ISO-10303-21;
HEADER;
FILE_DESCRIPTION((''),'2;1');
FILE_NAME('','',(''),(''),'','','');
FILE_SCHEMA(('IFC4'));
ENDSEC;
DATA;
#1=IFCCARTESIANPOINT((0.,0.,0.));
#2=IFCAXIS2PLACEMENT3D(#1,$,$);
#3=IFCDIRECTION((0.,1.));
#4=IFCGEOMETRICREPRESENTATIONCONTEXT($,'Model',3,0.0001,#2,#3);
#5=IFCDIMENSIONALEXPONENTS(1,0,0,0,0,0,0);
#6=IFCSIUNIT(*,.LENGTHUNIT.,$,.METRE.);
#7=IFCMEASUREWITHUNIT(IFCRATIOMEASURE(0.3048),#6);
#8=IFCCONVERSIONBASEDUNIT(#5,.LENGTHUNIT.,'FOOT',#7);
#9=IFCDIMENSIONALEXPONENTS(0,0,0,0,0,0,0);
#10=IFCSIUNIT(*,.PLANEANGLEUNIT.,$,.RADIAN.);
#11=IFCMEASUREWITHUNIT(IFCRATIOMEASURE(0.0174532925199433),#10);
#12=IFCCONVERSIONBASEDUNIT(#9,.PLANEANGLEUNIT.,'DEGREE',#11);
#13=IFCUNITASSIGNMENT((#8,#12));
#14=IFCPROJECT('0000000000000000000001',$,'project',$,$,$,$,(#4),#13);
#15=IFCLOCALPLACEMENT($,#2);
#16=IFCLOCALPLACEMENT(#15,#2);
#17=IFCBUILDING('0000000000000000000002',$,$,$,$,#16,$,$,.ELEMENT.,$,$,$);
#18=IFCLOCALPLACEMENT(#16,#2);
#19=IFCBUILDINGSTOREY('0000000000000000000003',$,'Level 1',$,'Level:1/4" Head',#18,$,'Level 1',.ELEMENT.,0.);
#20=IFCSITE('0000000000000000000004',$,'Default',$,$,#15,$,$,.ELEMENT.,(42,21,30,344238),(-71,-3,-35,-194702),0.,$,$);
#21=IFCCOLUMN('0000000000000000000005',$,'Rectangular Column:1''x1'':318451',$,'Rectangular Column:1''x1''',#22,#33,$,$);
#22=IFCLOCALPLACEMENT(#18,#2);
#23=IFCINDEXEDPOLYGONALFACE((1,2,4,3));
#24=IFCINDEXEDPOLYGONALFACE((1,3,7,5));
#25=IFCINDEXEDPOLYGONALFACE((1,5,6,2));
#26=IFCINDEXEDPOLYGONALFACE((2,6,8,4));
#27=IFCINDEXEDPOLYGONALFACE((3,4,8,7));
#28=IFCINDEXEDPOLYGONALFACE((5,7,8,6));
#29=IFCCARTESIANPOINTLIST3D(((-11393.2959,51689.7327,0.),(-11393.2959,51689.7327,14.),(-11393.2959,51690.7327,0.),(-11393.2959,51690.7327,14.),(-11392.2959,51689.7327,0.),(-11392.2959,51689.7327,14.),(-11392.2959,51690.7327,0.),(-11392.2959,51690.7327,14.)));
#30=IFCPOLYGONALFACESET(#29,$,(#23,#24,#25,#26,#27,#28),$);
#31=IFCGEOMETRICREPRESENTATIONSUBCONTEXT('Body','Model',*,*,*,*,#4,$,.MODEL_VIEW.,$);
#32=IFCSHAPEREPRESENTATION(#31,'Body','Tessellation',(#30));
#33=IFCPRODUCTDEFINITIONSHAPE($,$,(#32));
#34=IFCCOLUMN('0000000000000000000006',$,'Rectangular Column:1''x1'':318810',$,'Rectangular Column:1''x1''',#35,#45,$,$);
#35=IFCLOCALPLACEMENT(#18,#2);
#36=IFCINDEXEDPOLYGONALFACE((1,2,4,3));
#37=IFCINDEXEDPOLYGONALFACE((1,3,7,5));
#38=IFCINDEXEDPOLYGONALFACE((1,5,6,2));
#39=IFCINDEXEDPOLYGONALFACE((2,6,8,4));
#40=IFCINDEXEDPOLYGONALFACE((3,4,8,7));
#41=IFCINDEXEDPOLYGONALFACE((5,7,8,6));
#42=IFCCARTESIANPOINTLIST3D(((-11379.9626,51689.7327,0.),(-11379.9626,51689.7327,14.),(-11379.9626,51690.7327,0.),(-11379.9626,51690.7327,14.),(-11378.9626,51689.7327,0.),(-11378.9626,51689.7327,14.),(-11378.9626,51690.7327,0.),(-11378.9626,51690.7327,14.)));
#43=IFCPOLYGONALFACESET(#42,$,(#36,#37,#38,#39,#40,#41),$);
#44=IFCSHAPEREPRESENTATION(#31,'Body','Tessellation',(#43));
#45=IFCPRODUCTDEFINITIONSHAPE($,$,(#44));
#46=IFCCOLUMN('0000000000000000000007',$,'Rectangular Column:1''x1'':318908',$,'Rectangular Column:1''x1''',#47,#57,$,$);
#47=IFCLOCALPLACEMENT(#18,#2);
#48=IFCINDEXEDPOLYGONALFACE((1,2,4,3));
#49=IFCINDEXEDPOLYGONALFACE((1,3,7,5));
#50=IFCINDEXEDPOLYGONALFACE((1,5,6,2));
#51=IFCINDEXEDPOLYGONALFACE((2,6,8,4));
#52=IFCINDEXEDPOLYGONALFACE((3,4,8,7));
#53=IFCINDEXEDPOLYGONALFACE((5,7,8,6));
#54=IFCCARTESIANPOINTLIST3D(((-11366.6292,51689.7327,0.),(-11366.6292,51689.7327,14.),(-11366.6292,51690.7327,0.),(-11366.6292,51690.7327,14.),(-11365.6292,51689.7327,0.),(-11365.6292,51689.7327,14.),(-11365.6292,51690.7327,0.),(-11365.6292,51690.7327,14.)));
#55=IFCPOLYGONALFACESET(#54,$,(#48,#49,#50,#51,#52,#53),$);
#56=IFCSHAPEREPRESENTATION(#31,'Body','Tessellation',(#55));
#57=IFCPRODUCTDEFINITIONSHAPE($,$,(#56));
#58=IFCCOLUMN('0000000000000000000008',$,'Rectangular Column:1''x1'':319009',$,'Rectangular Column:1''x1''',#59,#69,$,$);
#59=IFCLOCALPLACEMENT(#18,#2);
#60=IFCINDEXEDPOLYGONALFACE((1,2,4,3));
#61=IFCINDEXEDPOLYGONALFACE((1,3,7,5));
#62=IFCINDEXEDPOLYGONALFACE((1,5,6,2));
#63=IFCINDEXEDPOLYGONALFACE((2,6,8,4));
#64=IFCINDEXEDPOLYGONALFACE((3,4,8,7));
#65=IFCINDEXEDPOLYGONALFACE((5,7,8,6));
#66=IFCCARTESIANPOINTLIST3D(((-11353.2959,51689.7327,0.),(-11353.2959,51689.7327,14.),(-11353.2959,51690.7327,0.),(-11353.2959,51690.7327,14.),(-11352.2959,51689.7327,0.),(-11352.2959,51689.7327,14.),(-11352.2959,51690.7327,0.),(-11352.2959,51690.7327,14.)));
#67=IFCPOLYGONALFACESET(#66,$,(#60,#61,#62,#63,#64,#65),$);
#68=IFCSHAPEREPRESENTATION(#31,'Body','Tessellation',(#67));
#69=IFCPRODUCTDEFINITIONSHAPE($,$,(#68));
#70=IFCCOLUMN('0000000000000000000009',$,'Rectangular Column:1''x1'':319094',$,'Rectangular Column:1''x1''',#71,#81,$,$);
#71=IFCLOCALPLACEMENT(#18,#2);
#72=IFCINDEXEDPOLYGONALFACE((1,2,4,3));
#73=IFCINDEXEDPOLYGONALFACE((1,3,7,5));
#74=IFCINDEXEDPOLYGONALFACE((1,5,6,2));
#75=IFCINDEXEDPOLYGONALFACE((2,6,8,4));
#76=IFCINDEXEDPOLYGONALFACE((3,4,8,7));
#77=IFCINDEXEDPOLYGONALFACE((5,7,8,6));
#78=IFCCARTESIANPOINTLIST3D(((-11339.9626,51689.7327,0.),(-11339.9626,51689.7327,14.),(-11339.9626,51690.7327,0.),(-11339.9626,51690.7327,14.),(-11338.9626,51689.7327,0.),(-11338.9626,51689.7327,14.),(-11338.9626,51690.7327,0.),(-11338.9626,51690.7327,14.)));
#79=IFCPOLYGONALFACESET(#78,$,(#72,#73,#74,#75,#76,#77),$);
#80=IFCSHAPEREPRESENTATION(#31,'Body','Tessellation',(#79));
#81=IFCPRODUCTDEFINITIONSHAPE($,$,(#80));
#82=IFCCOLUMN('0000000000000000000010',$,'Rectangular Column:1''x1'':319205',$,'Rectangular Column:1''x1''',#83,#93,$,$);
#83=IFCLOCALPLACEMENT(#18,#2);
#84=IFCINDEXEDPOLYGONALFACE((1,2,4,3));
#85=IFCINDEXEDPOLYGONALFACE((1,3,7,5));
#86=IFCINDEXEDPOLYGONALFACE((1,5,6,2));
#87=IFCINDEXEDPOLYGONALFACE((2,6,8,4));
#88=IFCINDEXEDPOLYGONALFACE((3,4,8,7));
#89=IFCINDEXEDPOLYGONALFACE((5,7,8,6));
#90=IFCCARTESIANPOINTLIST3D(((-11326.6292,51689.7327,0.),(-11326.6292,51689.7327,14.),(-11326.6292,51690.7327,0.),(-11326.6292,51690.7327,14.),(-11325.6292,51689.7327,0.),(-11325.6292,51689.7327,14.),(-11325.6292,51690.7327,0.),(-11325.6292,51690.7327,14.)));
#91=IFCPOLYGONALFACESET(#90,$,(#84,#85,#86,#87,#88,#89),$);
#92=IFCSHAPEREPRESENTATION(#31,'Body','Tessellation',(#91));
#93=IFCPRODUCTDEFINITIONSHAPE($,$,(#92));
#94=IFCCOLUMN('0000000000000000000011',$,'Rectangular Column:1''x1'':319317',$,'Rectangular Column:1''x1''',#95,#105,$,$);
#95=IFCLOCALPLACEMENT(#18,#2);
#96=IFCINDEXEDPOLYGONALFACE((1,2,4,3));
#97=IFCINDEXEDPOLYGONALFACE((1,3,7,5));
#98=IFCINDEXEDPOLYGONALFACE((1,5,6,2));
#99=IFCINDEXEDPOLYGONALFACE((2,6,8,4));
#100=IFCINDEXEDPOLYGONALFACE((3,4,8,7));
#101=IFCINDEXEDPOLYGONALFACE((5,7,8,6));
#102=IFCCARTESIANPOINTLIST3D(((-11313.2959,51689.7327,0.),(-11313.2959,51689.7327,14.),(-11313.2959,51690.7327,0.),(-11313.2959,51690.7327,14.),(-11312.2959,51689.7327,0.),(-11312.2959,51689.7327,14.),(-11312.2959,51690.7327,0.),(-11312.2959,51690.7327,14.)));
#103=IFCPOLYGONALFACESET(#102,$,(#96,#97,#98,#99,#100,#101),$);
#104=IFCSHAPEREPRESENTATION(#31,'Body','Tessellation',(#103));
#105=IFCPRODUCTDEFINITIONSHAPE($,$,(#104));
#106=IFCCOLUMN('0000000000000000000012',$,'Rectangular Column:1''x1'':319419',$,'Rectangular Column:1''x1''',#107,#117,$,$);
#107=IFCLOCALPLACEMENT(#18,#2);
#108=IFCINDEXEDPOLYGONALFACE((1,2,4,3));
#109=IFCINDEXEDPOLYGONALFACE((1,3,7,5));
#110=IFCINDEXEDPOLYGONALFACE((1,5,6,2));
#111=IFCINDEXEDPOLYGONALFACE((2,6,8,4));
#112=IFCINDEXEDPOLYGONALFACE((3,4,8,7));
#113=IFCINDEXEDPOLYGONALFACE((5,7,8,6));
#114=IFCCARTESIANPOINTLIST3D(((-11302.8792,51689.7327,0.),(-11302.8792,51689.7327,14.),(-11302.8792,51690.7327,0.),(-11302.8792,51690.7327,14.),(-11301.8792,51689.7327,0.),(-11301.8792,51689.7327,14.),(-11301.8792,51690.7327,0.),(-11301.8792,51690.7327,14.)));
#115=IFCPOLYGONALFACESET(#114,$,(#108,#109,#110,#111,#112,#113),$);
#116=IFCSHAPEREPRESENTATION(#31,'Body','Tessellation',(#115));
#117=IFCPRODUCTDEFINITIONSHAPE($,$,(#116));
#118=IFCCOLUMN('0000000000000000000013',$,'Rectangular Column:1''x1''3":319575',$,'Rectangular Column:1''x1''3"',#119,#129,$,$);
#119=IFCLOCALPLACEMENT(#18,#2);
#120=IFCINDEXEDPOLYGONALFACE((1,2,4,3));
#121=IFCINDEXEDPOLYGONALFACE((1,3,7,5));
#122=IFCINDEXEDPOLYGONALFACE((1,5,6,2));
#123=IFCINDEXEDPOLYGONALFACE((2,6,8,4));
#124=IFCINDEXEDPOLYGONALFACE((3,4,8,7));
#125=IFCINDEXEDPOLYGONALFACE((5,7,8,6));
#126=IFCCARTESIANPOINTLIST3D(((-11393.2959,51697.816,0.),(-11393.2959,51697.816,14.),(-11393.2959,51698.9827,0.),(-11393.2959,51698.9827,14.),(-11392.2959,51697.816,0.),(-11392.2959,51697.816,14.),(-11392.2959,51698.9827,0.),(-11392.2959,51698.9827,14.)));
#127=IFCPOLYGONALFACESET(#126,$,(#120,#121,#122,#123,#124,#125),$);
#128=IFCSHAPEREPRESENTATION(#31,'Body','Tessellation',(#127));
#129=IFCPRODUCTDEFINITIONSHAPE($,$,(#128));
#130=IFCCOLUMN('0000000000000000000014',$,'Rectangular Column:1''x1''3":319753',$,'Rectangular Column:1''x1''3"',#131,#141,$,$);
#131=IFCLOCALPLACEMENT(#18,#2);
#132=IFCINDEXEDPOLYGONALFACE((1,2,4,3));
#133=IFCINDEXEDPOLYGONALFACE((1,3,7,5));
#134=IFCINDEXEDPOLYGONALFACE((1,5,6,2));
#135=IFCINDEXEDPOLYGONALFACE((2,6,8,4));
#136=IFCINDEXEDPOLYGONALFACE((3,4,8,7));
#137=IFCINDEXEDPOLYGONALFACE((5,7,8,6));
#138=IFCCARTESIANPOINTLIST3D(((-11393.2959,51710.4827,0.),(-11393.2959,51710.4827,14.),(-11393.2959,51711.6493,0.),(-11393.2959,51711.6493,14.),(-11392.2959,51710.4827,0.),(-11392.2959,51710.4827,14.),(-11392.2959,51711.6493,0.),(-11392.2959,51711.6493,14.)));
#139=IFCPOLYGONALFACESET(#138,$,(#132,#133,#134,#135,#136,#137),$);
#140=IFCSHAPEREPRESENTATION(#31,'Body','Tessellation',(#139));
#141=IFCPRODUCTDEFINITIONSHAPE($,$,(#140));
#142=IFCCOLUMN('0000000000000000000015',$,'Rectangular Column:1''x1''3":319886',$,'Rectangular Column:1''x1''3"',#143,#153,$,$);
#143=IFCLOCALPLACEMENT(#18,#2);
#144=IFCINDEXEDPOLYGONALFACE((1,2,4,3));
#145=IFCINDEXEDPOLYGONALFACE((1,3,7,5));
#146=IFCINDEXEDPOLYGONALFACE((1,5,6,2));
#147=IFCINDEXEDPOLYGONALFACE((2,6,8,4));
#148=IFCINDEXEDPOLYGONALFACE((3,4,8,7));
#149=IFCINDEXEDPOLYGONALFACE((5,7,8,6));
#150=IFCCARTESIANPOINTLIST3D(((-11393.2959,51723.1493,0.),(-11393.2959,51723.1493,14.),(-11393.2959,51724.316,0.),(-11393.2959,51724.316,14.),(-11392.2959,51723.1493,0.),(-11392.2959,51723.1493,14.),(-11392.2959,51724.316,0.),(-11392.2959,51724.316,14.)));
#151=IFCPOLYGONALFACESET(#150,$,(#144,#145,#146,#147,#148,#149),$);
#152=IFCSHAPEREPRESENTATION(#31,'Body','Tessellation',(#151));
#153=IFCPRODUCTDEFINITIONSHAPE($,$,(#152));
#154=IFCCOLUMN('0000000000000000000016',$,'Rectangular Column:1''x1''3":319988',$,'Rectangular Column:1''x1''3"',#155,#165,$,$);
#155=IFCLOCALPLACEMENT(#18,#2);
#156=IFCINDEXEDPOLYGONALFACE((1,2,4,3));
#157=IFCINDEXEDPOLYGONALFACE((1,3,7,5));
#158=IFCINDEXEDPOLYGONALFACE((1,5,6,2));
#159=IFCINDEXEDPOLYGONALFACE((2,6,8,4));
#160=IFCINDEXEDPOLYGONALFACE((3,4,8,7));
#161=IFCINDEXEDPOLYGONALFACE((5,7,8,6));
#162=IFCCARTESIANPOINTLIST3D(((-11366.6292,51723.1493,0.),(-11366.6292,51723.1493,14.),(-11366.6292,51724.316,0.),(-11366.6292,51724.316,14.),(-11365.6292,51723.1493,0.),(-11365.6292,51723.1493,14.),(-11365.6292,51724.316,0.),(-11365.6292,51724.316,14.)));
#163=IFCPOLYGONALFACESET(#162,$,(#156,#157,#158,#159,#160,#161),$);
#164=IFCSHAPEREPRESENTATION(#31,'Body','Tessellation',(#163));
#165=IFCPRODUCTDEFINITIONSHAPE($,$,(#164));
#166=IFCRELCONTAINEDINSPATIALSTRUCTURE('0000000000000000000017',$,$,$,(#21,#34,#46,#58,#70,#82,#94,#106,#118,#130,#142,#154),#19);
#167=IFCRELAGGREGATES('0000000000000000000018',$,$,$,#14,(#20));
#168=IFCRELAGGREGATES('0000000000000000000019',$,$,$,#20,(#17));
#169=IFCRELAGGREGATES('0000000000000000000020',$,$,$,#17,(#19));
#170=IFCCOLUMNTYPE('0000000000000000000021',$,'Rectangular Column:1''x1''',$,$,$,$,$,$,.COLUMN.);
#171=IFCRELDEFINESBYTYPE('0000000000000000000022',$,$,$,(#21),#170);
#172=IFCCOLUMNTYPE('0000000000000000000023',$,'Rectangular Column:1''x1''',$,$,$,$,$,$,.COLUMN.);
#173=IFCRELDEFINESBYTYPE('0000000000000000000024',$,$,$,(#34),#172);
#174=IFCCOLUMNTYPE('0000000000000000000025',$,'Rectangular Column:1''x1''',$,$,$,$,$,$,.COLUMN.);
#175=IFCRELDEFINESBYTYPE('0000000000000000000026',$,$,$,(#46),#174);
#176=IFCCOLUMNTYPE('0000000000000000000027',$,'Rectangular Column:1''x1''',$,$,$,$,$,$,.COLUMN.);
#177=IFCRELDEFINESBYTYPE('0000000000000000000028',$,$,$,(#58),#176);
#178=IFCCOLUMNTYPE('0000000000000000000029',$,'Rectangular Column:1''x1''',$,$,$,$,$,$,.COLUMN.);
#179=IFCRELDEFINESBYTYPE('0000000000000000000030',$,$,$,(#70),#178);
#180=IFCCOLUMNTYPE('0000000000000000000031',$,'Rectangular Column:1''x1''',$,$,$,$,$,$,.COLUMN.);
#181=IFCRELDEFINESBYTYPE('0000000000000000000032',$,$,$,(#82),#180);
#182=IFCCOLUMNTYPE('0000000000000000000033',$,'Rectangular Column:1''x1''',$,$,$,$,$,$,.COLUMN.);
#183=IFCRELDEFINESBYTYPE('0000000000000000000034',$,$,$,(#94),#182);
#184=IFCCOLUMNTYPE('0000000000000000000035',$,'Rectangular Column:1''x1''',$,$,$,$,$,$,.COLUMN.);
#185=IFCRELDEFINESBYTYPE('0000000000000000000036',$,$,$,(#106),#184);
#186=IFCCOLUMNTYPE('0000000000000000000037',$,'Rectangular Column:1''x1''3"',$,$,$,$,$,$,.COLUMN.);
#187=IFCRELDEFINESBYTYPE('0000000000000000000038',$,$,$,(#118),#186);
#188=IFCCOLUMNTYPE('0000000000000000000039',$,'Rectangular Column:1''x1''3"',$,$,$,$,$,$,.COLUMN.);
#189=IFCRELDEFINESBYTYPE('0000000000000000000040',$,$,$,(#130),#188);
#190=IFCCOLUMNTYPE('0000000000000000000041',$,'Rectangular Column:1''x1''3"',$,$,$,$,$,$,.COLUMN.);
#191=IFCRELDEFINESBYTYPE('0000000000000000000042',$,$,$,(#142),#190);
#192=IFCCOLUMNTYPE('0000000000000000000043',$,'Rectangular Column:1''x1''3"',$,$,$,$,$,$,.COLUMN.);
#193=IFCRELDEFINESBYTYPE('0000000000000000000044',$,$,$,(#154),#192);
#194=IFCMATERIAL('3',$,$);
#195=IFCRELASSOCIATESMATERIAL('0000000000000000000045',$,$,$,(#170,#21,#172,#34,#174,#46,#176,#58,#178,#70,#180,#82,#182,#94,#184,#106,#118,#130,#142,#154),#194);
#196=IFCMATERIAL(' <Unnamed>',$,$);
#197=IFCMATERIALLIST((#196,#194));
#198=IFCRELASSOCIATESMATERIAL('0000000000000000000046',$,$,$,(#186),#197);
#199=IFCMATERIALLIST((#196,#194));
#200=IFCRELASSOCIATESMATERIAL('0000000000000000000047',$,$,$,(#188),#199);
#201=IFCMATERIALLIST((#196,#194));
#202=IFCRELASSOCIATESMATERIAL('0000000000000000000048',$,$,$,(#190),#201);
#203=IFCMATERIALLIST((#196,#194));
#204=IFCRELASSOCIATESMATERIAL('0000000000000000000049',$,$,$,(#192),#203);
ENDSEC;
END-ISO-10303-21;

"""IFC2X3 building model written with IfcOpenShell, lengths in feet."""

from ifc_helpers import new_model, entity, si_unit, converted_unit, direction, frame, frame_2d, origin, origin_2d_with_axis, place, context, subcontext, project, spatial, rectangle, extrude, source, transform, mapped, material, material_list, type_object, type_shapes, element, save


model = new_model("IFC2X3")

# Units and contexts
model_context = context("Model", 3, precision=0.0001, world=origin(), true_north=direction((0.0, 1.0)))
body_context = subcontext(model_context, "Body", "Model", "MODEL_VIEW")
ifc_project = project(units=[converted_unit("LENGTHUNIT", "FOOT", entity("IfcRatioMeasure", 0.3048), si_unit("LENGTHUNIT", "METRE"), dimensions=[1, 0, 0, 0, 0, 0, 0]), converted_unit("PLANEANGLEUNIT", "DEGREE", entity("IfcRatioMeasure", 0.0174532925199433), si_unit("PLANEANGLEUNIT", "RADIAN"), dimensions=[0, 0, 0, 0, 0, 0, 0])], contexts=[model_context])

# Site, building, storey
site_placement = place(None, origin())
site = spatial("IfcSite", under=ifc_project, at=site_placement, Name="Default", CompositionType="ELEMENT", RefLatitude=(42, 21, 30, 344238), RefLongitude=(-71, -3, -35, -194702), RefElevation=0.0)
building_placement = place(site_placement, origin())
building = spatial("IfcBuilding", under=site, at=building_placement, CompositionType="ELEMENT")
storey_placement = place(building_placement, origin())
storey = spatial("IfcBuildingStorey", under=building, at=storey_placement, Name="Level 1", ObjectType="Level:1/4\" Head", LongName="Level 1", CompositionType="ELEMENT", Elevation=0.0)

# Columns
ifc_material_1 = material(Name="3")
column_type_1 = type_object("IfcColumnType", Name="Rectangular Column:1'x1'", PredefinedType="COLUMN", material=ifc_material_1)
shared_shape_1 = source(origin(), body_context, "Body", "SweptSolid", [
    extrude(rectangle(XDim=1.0, YDim=1.0, at=origin_2d_with_axis()), frame((-11392.7959, 51690.2327, 0.0), z_axis=(0.0, 0.0, 1.0), x_axis=(-1.0, 0.0, 0.0)), (0.0, 0.0, 1.0), 14.0),
])
type_shapes(column_type_1, [shared_shape_1])
column_1_placement = place(storey_placement, origin())
element("IfcColumn", 1, at=column_1_placement, inside=storey, type_object=column_type_1, material=ifc_material_1, Name="Rectangular Column:1'x1':318451", ObjectType="Rectangular Column:1'x1'", context=body_context, shape_type="MappedRepresentation", body=[
    mapped(shared_shape_1, transform((0.0, 0.0, 0.0), scale=1.0)),
])
column_type_2 = type_object("IfcColumnType", Name="Rectangular Column:1'x1'", PredefinedType="COLUMN", material=ifc_material_1)
shared_shape_2 = source(origin(), body_context, "Body", "SweptSolid", [
    extrude(rectangle(XDim=1.0, YDim=1.0, at=origin_2d_with_axis()), frame((-11379.4626, 51690.2327, 0.0), z_axis=(0.0, 0.0, 1.0), x_axis=(-1.0, 0.0, 0.0)), (0.0, 0.0, 1.0), 14.0),
])
type_shapes(column_type_2, [shared_shape_2])
column_2_placement = place(storey_placement, origin())
element("IfcColumn", 2, at=column_2_placement, inside=storey, type_object=column_type_2, material=ifc_material_1, Name="Rectangular Column:1'x1':318810", ObjectType="Rectangular Column:1'x1'", context=body_context, shape_type="MappedRepresentation", body=[
    mapped(shared_shape_2, transform((0.0, 0.0, 0.0), scale=1.0)),
])
column_type_3 = type_object("IfcColumnType", Name="Rectangular Column:1'x1'", PredefinedType="COLUMN", material=ifc_material_1)
shared_shape_3 = source(origin(), body_context, "Body", "SweptSolid", [
    extrude(rectangle(XDim=1.0, YDim=1.0, at=origin_2d_with_axis()), frame((-11366.1292, 51690.2327, 0.0), z_axis=(0.0, 0.0, 1.0), x_axis=(-1.0, 0.0, 0.0)), (0.0, 0.0, 1.0), 14.0),
])
type_shapes(column_type_3, [shared_shape_3])
column_3_placement = place(storey_placement, origin())
element("IfcColumn", 3, at=column_3_placement, inside=storey, type_object=column_type_3, material=ifc_material_1, Name="Rectangular Column:1'x1':318908", ObjectType="Rectangular Column:1'x1'", context=body_context, shape_type="MappedRepresentation", body=[
    mapped(shared_shape_3, transform((0.0, 0.0, 0.0), scale=1.0)),
])
column_type_4 = type_object("IfcColumnType", Name="Rectangular Column:1'x1'", PredefinedType="COLUMN", material=ifc_material_1)
shared_shape_4 = source(origin(), body_context, "Body", "SweptSolid", [
    extrude(rectangle(XDim=1.0, YDim=1.0, at=origin_2d_with_axis()), frame((-11352.7959, 51690.2327, 0.0), z_axis=(0.0, 0.0, 1.0), x_axis=(-1.0, 0.0, 0.0)), (0.0, 0.0, 1.0), 14.0),
])
type_shapes(column_type_4, [shared_shape_4])
column_4_placement = place(storey_placement, origin())
element("IfcColumn", 4, at=column_4_placement, inside=storey, type_object=column_type_4, material=ifc_material_1, Name="Rectangular Column:1'x1':319009", ObjectType="Rectangular Column:1'x1'", context=body_context, shape_type="MappedRepresentation", body=[
    mapped(shared_shape_4, transform((0.0, 0.0, 0.0), scale=1.0)),
])
column_type_5 = type_object("IfcColumnType", Name="Rectangular Column:1'x1'", PredefinedType="COLUMN", material=ifc_material_1)
shared_shape_5 = source(origin(), body_context, "Body", "SweptSolid", [
    extrude(rectangle(XDim=1.0, YDim=1.0, at=origin_2d_with_axis()), frame((-11339.4626, 51690.2327, 0.0), z_axis=(0.0, 0.0, 1.0), x_axis=(-1.0, 0.0, 0.0)), (0.0, 0.0, 1.0), 14.0),
])
type_shapes(column_type_5, [shared_shape_5])
column_5_placement = place(storey_placement, origin())
element("IfcColumn", 5, at=column_5_placement, inside=storey, type_object=column_type_5, material=ifc_material_1, Name="Rectangular Column:1'x1':319094", ObjectType="Rectangular Column:1'x1'", context=body_context, shape_type="MappedRepresentation", body=[
    mapped(shared_shape_5, transform((0.0, 0.0, 0.0), scale=1.0)),
])
column_type_6 = type_object("IfcColumnType", Name="Rectangular Column:1'x1'", PredefinedType="COLUMN", material=ifc_material_1)
shared_shape_6 = source(origin(), body_context, "Body", "SweptSolid", [
    extrude(rectangle(XDim=1.0, YDim=1.0, at=origin_2d_with_axis()), frame((-11326.1292, 51690.2327, 0.0), z_axis=(0.0, 0.0, 1.0), x_axis=(-1.0, 0.0, 0.0)), (0.0, 0.0, 1.0), 14.0),
])
type_shapes(column_type_6, [shared_shape_6])
column_6_placement = place(storey_placement, origin())
element("IfcColumn", 6, at=column_6_placement, inside=storey, type_object=column_type_6, material=ifc_material_1, Name="Rectangular Column:1'x1':319205", ObjectType="Rectangular Column:1'x1'", context=body_context, shape_type="MappedRepresentation", body=[
    mapped(shared_shape_6, transform((0.0, 0.0, 0.0), scale=1.0)),
])
column_type_7 = type_object("IfcColumnType", Name="Rectangular Column:1'x1'", PredefinedType="COLUMN", material=ifc_material_1)
shared_shape_7 = source(origin(), body_context, "Body", "SweptSolid", [
    extrude(rectangle(XDim=1.0, YDim=1.0, at=origin_2d_with_axis()), frame((-11312.7959, 51690.2327, 0.0), z_axis=(0.0, 0.0, 1.0), x_axis=(-1.0, 0.0, 0.0)), (0.0, 0.0, 1.0), 14.0),
])
type_shapes(column_type_7, [shared_shape_7])
column_7_placement = place(storey_placement, origin())
element("IfcColumn", 7, at=column_7_placement, inside=storey, type_object=column_type_7, material=ifc_material_1, Name="Rectangular Column:1'x1':319317", ObjectType="Rectangular Column:1'x1'", context=body_context, shape_type="MappedRepresentation", body=[
    mapped(shared_shape_7, transform((0.0, 0.0, 0.0), scale=1.0)),
])
column_type_8 = type_object("IfcColumnType", Name="Rectangular Column:1'x1'", PredefinedType="COLUMN", material=ifc_material_1)
shared_shape_8 = source(origin(), body_context, "Body", "SweptSolid", [
    extrude(rectangle(XDim=1.0, YDim=1.0, at=origin_2d_with_axis()), frame((-11302.3792, 51690.2327, 0.0), z_axis=(0.0, 0.0, 1.0), x_axis=(-1.0, 0.0, 0.0)), (0.0, 0.0, 1.0), 14.0),
])
type_shapes(column_type_8, [shared_shape_8])
column_8_placement = place(storey_placement, origin())
element("IfcColumn", 8, at=column_8_placement, inside=storey, type_object=column_type_8, material=ifc_material_1, Name="Rectangular Column:1'x1':319419", ObjectType="Rectangular Column:1'x1'", context=body_context, shape_type="MappedRepresentation", body=[
    mapped(shared_shape_8, transform((0.0, 0.0, 0.0), scale=1.0)),
])
ifc_material_2 = material(Name=" <Unnamed>")
ifc_material_list_1 = material_list([ifc_material_2, ifc_material_1])
column_type_9 = type_object("IfcColumnType", Name="Rectangular Column:1'x1'3\"", PredefinedType="COLUMN", material=ifc_material_list_1)
shared_shape_9 = source(origin(), body_context, "Body", "SweptSolid", [
    extrude(rectangle(XDim=1.1667, YDim=1.0, at=frame_2d((0.0, 0.0), x_axis=(1.0, 0.0))), frame((-11392.7959, 51698.3993, 0.0), z_axis=(0.0, 0.0, 1.0), x_axis=(0.0, -1.0, 0.0)), (0.0, 0.0, 1.0), 14.0),
])
type_shapes(column_type_9, [shared_shape_9])
column_9_placement = place(storey_placement, origin())
element("IfcColumn", 9, at=column_9_placement, inside=storey, type_object=column_type_9, material=ifc_material_1, Name="Rectangular Column:1'x1'3\":319575", ObjectType="Rectangular Column:1'x1'3\"", context=body_context, shape_type="MappedRepresentation", body=[
    mapped(shared_shape_9, transform((0.0, 0.0, 0.0), scale=1.0)),
])
ifc_material_list_2 = material_list([ifc_material_2, ifc_material_1])
column_type_10 = type_object("IfcColumnType", Name="Rectangular Column:1'x1'3\"", PredefinedType="COLUMN", material=ifc_material_list_2)
shared_shape_10 = source(origin(), body_context, "Body", "SweptSolid", [
    extrude(rectangle(XDim=1.1667, YDim=1.0, at=frame_2d((0.0, 0.0), x_axis=(1.0, 0.0))), frame((-11392.7959, 51711.066, 0.0), z_axis=(0.0, 0.0, 1.0), x_axis=(0.0, -1.0, 0.0)), (0.0, 0.0, 1.0), 14.0),
])
type_shapes(column_type_10, [shared_shape_10])
column_10_placement = place(storey_placement, origin())
element("IfcColumn", 10, at=column_10_placement, inside=storey, type_object=column_type_10, material=ifc_material_1, Name="Rectangular Column:1'x1'3\":319753", ObjectType="Rectangular Column:1'x1'3\"", context=body_context, shape_type="MappedRepresentation", body=[
    mapped(shared_shape_10, transform((0.0, 0.0, 0.0), scale=1.0)),
])
ifc_material_list_3 = material_list([ifc_material_2, ifc_material_1])
column_type_11 = type_object("IfcColumnType", Name="Rectangular Column:1'x1'3\"", PredefinedType="COLUMN", material=ifc_material_list_3)
shared_shape_11 = source(origin(), body_context, "Body", "SweptSolid", [
    extrude(rectangle(XDim=1.1667, YDim=1.0, at=frame_2d((0.0, 0.0), x_axis=(1.0, 0.0))), frame((-11392.7959, 51723.7327, 0.0), z_axis=(0.0, 0.0, 1.0), x_axis=(0.0, -1.0, 0.0)), (0.0, 0.0, 1.0), 14.0),
])
type_shapes(column_type_11, [shared_shape_11])
column_11_placement = place(storey_placement, origin())
element("IfcColumn", 11, at=column_11_placement, inside=storey, type_object=column_type_11, material=ifc_material_1, Name="Rectangular Column:1'x1'3\":319886", ObjectType="Rectangular Column:1'x1'3\"", context=body_context, shape_type="MappedRepresentation", body=[
    mapped(shared_shape_11, transform((0.0, 0.0, 0.0), scale=1.0)),
])
ifc_material_list_4 = material_list([ifc_material_2, ifc_material_1])
column_type_12 = type_object("IfcColumnType", Name="Rectangular Column:1'x1'3\"", PredefinedType="COLUMN", material=ifc_material_list_4)
shared_shape_12 = source(origin(), body_context, "Body", "SweptSolid", [
    extrude(rectangle(XDim=1.1667, YDim=1.0, at=frame_2d((0.0, 0.0), x_axis=(1.0, 0.0))), frame((-11366.1292, 51723.7327, 0.0), z_axis=(0.0, 0.0, 1.0), x_axis=(0.0, -1.0, 0.0)), (0.0, 0.0, 1.0), 14.0),
])
type_shapes(column_type_12, [shared_shape_12])
column_12_placement = place(storey_placement, origin())
element("IfcColumn", 12, at=column_12_placement, inside=storey, type_object=column_type_12, material=ifc_material_1, Name="Rectangular Column:1'x1'3\":319988", ObjectType="Rectangular Column:1'x1'3\"", context=body_context, shape_type="MappedRepresentation", body=[
    mapped(shared_shape_12, transform((0.0, 0.0, 0.0), scale=1.0)),
])

save(model, "model.ifc")
